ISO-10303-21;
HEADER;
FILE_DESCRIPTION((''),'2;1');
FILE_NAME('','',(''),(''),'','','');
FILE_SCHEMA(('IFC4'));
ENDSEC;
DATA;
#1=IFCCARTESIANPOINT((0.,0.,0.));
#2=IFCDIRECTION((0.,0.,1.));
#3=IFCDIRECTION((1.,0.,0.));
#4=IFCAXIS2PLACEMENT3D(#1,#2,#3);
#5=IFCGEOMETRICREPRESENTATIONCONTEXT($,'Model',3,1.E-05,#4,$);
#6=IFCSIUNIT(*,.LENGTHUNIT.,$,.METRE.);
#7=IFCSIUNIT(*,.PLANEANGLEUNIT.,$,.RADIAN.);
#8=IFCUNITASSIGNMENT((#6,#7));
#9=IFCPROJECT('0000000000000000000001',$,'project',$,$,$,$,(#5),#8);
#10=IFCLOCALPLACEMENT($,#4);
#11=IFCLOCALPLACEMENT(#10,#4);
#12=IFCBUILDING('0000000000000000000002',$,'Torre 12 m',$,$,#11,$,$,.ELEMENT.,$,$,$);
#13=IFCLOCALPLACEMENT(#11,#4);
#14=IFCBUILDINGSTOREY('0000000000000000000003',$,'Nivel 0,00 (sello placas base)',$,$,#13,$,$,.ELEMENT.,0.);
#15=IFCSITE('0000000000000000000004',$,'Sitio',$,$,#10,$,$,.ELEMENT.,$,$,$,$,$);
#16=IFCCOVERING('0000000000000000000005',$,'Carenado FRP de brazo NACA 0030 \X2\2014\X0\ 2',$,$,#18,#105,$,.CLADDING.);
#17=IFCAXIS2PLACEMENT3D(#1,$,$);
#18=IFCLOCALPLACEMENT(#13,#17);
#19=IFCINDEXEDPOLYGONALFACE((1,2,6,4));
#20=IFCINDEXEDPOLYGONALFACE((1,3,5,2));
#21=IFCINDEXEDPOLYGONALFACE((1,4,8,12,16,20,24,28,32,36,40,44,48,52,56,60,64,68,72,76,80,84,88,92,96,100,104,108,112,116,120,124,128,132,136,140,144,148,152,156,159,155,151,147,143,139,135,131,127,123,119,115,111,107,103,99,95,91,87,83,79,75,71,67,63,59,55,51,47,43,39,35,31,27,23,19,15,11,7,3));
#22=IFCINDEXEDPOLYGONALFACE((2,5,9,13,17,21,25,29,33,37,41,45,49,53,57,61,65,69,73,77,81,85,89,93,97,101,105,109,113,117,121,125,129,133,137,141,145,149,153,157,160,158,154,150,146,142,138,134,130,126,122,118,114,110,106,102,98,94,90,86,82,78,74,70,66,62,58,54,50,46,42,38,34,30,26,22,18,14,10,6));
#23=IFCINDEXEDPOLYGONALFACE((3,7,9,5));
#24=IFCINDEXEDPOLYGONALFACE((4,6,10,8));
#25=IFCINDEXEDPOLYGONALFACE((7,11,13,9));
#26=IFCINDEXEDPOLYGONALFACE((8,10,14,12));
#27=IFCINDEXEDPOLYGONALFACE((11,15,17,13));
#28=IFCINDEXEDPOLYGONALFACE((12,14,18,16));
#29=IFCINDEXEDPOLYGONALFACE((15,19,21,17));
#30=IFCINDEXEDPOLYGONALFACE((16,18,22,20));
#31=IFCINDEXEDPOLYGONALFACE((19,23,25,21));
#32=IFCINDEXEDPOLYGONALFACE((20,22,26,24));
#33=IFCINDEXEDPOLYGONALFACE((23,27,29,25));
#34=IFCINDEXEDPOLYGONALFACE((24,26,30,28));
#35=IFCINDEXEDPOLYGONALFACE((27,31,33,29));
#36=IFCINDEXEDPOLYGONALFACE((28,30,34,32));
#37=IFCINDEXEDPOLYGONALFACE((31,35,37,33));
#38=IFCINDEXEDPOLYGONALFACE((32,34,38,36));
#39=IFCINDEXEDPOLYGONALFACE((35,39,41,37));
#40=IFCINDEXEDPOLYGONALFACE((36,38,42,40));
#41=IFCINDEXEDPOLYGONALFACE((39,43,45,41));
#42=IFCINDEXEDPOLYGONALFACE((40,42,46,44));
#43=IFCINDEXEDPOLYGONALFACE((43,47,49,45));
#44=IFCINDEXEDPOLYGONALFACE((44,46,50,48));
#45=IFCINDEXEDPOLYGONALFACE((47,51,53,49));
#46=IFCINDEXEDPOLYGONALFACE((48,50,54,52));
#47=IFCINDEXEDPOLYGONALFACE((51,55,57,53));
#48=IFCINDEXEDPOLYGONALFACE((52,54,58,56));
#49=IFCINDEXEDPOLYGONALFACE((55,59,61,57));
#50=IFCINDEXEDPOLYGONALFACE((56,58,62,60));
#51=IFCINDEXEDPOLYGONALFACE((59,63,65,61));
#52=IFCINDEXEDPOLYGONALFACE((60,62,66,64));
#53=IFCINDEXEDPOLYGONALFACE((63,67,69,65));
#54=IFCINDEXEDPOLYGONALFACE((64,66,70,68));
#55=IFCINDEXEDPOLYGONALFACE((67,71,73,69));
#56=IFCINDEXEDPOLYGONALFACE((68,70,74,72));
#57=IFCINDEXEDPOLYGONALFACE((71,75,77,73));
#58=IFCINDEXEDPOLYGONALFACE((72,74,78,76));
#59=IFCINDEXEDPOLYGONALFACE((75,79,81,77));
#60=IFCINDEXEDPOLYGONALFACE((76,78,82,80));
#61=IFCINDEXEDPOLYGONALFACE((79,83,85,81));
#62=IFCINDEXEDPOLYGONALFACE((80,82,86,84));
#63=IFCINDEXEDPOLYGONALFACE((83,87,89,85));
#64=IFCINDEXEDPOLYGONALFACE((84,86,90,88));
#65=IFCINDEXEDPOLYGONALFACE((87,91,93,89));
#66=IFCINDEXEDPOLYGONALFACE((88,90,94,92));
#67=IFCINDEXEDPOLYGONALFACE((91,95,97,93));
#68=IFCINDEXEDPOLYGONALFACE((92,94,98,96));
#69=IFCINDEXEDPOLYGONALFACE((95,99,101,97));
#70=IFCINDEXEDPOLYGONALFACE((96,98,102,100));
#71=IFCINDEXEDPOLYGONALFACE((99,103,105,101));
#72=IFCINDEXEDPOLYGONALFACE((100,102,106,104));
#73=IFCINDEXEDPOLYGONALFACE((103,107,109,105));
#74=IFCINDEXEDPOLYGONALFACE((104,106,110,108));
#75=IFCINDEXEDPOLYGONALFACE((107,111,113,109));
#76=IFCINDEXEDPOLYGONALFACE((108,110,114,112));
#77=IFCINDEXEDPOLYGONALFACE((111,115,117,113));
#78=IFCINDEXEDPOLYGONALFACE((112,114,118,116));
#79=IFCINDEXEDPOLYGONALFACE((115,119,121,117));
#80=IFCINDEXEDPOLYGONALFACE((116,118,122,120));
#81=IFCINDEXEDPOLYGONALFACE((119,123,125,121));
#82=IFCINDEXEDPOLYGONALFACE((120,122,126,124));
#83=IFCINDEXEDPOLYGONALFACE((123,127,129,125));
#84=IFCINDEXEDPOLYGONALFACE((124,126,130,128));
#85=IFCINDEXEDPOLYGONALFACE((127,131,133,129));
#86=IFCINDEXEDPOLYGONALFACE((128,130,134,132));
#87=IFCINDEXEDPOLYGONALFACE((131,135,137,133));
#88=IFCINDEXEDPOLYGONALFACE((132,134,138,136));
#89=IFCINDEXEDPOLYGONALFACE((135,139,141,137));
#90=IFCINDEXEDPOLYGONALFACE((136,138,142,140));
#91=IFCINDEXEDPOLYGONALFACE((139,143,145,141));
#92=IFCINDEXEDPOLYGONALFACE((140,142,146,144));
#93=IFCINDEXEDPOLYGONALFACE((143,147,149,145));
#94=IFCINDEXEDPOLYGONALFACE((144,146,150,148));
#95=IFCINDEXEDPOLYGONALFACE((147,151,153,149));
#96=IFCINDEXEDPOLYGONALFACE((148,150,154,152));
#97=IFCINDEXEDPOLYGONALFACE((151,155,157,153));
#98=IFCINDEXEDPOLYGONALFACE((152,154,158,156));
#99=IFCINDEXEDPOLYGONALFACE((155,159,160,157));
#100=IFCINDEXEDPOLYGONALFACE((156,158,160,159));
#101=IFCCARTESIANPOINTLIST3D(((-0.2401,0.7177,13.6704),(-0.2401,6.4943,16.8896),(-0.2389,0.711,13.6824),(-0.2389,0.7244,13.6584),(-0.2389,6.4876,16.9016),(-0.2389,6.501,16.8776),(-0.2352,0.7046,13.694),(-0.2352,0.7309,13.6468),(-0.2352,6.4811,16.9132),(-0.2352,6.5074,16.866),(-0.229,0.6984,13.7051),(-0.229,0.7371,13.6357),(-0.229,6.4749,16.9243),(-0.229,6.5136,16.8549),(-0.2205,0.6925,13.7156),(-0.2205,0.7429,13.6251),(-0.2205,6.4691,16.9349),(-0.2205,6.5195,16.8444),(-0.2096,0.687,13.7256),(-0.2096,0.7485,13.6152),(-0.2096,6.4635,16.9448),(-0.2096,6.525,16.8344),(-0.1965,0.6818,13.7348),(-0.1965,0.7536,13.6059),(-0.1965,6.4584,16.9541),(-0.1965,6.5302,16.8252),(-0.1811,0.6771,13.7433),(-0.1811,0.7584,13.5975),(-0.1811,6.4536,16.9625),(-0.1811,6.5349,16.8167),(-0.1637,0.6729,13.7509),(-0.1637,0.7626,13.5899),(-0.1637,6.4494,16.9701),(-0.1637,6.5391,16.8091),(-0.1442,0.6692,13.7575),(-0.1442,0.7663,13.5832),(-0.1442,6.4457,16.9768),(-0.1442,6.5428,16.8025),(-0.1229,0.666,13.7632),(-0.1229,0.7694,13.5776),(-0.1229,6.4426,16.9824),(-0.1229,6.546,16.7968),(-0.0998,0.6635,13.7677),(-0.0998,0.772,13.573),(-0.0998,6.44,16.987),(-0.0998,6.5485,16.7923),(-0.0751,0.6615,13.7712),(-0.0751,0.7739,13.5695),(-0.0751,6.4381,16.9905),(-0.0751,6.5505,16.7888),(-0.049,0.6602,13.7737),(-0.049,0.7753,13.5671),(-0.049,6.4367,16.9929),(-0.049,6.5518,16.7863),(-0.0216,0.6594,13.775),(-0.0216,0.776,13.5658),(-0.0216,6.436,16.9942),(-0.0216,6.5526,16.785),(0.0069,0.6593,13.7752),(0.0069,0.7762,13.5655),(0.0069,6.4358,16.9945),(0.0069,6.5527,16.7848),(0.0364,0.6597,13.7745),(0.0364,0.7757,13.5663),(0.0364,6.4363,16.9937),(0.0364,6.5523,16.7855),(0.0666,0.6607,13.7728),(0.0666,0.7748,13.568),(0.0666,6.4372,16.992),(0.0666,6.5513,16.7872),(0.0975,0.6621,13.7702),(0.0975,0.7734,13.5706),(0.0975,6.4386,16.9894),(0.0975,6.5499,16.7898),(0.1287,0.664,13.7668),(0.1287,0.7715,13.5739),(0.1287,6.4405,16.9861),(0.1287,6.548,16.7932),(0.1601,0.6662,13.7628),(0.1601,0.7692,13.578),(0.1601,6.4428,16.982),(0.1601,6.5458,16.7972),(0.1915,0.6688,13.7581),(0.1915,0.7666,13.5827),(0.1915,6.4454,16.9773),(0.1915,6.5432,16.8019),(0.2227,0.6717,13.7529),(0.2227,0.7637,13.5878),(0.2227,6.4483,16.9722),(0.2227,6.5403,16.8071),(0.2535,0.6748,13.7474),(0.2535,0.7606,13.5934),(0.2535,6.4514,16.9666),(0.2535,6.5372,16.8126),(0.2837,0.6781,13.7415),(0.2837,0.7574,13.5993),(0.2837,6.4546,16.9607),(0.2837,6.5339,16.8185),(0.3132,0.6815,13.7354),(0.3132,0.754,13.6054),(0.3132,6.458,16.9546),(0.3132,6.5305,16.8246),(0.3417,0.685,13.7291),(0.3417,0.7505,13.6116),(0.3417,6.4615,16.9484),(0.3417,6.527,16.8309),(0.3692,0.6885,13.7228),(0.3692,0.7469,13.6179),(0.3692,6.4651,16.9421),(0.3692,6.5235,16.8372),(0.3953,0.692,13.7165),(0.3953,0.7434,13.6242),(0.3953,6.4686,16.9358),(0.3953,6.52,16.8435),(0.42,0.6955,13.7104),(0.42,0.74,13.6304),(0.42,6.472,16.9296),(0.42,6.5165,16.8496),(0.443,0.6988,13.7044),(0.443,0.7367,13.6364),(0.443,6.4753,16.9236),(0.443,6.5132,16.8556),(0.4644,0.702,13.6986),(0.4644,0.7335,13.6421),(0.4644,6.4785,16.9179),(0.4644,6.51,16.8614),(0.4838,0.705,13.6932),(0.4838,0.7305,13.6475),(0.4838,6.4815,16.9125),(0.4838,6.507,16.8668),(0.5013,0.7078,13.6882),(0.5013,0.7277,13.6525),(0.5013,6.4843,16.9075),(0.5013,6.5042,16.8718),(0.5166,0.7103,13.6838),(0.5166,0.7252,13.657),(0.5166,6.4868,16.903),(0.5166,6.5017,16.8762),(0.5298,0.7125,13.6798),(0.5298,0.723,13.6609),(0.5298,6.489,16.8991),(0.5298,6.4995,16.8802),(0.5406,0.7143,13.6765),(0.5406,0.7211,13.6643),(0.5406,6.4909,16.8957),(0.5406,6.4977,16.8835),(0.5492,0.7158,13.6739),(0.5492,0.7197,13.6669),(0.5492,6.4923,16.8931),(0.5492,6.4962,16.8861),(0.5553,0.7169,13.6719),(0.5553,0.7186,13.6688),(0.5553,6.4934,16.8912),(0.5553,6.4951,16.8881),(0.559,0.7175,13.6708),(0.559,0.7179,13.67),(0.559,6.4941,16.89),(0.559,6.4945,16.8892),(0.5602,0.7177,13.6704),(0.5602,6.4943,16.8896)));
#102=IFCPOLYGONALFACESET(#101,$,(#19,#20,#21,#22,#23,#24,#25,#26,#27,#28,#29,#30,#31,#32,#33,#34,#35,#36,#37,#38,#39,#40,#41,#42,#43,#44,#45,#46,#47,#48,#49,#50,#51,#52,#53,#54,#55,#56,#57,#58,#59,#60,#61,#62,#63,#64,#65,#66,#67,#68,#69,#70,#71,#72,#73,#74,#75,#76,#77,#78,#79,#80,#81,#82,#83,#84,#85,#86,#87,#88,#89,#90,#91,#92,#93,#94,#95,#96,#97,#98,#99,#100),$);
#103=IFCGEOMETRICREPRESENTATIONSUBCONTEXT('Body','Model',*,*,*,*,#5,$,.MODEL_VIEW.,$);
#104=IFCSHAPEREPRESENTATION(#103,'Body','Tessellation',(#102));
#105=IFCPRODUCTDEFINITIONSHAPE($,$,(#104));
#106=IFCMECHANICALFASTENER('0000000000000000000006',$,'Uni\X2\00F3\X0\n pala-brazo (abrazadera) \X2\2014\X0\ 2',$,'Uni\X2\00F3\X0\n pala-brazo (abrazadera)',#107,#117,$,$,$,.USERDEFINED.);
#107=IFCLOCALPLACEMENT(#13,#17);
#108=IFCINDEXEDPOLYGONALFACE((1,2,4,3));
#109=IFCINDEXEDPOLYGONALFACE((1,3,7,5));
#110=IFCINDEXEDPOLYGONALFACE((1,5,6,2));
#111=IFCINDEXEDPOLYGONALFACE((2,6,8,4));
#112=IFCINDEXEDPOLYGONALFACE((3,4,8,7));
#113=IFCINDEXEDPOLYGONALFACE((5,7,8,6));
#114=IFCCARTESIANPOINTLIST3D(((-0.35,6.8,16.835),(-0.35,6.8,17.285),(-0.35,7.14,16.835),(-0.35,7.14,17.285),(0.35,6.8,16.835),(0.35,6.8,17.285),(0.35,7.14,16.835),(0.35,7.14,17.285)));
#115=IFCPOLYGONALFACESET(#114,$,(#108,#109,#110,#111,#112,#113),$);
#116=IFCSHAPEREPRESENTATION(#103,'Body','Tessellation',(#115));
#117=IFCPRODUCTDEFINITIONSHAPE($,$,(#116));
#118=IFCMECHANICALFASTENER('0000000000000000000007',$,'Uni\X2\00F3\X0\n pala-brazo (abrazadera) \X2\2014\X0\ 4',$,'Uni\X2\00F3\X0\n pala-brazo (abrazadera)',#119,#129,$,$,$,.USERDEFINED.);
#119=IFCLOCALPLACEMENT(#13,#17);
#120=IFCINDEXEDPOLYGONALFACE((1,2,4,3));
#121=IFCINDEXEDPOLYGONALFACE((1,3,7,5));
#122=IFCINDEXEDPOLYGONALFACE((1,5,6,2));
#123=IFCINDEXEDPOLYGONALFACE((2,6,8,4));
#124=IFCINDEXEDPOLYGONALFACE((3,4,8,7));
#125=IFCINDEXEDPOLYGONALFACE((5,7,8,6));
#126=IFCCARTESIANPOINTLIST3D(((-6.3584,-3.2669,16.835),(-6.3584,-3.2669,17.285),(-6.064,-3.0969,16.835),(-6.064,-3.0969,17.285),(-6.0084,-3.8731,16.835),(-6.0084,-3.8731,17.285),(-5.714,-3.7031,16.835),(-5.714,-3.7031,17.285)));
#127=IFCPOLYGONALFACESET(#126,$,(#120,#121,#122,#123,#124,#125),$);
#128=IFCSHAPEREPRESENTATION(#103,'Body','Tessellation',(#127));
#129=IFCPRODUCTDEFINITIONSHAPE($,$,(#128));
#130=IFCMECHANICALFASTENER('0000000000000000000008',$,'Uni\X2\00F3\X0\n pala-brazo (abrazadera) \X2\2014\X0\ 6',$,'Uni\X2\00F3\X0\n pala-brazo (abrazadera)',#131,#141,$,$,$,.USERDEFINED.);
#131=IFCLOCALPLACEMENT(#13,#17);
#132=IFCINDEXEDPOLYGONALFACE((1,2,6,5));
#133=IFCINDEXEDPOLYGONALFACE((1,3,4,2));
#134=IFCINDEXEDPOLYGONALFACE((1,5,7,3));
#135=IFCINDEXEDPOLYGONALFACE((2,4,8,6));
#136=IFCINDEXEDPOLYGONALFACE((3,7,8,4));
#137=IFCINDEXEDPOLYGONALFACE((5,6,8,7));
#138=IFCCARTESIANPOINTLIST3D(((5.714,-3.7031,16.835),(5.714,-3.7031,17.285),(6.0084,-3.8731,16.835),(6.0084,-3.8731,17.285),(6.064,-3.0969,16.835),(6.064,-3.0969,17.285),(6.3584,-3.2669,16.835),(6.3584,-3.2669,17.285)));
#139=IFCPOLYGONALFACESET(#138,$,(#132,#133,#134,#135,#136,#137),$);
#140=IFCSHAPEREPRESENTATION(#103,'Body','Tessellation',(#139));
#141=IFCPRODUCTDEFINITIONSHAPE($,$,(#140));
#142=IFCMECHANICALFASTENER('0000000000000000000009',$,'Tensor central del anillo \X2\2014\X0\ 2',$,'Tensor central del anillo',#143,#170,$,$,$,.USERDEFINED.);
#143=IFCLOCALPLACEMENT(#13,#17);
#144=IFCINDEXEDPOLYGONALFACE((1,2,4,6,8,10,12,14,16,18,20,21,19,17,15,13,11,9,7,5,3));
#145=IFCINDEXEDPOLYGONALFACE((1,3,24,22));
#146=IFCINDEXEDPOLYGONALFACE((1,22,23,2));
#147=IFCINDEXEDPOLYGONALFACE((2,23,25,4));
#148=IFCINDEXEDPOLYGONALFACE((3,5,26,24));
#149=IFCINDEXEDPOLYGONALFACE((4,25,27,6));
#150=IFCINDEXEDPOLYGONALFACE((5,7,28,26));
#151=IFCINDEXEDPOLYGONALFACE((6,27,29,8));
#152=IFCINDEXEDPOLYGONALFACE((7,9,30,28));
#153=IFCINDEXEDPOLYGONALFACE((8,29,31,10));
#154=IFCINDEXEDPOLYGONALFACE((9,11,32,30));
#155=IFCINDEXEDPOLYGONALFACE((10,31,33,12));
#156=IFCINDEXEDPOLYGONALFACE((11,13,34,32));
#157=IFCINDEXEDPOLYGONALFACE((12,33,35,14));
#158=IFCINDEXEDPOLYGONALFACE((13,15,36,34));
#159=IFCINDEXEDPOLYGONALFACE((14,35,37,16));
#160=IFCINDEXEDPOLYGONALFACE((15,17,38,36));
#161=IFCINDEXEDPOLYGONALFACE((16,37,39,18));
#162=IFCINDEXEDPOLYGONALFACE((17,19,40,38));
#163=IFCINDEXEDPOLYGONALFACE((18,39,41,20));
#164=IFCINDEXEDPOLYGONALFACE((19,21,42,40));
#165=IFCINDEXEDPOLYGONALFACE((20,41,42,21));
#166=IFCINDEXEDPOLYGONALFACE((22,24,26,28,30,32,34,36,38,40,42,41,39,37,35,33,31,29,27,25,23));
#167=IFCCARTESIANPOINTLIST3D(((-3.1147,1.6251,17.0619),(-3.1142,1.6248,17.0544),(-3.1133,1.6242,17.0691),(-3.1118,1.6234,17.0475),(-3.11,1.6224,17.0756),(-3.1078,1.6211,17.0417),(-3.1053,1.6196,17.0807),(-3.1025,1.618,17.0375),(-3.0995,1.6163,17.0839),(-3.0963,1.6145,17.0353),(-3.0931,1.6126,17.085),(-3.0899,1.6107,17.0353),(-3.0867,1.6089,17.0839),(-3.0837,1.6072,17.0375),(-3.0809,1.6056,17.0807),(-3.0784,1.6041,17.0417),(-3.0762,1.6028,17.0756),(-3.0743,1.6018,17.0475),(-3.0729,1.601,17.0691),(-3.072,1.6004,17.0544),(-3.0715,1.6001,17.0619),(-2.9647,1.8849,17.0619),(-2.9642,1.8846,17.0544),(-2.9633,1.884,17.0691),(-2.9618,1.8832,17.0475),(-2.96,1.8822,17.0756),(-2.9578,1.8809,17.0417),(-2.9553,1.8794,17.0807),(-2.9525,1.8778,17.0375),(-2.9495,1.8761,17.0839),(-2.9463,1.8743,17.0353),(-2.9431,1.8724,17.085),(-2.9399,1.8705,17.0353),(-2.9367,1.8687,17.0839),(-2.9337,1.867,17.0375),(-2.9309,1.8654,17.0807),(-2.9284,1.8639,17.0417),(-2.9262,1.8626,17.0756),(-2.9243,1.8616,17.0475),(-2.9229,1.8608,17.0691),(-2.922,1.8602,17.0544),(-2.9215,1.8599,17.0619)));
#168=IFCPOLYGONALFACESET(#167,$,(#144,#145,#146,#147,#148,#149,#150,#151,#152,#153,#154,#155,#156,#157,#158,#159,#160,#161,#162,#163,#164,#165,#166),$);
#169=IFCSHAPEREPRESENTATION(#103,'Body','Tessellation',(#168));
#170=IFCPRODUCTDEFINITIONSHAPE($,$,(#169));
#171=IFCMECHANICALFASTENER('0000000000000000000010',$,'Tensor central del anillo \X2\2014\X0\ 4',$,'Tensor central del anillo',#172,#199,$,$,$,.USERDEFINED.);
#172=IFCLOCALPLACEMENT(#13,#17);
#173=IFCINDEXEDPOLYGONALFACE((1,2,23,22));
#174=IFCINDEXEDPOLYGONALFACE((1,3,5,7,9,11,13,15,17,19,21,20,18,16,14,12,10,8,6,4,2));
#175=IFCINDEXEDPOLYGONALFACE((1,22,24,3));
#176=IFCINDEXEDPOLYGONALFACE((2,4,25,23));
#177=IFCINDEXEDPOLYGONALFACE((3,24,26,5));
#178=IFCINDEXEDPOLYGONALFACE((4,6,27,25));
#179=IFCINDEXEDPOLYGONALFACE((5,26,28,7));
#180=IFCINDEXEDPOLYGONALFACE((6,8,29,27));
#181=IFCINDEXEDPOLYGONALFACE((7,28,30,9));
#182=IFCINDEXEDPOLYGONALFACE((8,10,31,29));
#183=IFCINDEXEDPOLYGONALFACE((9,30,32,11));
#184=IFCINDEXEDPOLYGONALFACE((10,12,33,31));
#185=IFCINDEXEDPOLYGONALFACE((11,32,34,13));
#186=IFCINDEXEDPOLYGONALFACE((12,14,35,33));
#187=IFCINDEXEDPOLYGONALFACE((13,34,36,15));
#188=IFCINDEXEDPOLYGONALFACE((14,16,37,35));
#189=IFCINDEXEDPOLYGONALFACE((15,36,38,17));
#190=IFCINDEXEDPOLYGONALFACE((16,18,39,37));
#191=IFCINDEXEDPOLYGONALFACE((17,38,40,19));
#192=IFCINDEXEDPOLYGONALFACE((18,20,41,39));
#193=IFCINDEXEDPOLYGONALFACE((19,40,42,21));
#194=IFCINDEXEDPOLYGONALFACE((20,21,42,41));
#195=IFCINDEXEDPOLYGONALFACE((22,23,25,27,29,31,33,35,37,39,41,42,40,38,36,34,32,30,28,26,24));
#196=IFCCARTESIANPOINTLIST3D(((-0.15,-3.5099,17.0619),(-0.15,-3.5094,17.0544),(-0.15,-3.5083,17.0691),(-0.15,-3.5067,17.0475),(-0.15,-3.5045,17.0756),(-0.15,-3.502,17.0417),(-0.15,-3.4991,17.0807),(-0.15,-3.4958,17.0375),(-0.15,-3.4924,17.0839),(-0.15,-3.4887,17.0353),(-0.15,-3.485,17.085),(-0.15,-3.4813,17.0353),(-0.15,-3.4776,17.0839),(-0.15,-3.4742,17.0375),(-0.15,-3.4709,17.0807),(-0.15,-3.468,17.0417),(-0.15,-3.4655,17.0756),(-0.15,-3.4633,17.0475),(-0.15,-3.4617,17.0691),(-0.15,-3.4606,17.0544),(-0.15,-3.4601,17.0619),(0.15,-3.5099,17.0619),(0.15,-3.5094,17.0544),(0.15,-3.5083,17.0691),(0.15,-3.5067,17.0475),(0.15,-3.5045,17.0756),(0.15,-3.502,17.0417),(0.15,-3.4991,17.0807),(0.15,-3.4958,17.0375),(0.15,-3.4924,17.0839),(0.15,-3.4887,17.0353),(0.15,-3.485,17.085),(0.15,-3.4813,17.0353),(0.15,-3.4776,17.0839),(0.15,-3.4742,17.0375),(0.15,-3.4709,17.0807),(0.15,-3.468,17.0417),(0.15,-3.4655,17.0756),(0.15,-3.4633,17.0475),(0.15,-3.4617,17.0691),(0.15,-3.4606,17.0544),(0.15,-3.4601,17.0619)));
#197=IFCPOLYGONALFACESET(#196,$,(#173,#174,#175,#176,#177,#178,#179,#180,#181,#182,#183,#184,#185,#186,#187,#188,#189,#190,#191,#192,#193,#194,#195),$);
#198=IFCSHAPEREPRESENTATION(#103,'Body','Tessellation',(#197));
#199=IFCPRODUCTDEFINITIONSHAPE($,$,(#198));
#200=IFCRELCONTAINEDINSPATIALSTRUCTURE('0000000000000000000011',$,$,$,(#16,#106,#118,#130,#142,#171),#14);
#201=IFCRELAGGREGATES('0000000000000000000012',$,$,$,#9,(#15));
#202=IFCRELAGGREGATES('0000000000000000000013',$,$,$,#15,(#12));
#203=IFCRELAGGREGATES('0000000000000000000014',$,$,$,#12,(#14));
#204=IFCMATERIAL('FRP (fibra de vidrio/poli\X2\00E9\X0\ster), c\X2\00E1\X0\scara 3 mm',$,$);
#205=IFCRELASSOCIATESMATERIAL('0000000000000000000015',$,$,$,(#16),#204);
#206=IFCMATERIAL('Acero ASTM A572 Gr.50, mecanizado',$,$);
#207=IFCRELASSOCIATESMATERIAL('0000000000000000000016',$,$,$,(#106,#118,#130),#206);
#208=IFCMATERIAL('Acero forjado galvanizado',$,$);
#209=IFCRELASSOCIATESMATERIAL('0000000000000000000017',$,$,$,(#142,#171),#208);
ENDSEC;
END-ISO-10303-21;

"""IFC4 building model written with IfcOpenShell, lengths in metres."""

from ifc_helpers import new_model, si_unit, frame, origin, origin_with_axes, origin_2d, place, context, subcontext, project, spatial, polyline, rectangle, circle, outline, extrude, material, element, save


model = new_model("IFC4")

# Units and contexts
model_context = context("Model", 3, precision=1e-05, world=origin_with_axes())
body_context = subcontext(model_context, "Body", "Model", "MODEL_VIEW")
ifc_project = project(units=[si_unit("LENGTHUNIT", "METRE"), si_unit("PLANEANGLEUNIT", "RADIAN")], contexts=[model_context])

# Site, building, storey
site_placement = place(None, origin_with_axes())
site = spatial("IfcSite", under=ifc_project, at=site_placement, Name="Sitio", CompositionType="ELEMENT")
building_placement = place(site_placement, origin_with_axes())
building = spatial("IfcBuilding", under=site, at=building_placement, Name="Torre 12 m", CompositionType="ELEMENT")
storey_placement = place(building_placement, origin_with_axes())
storey = spatial("IfcBuildingStorey", under=building, at=storey_placement, Name="Nivel 0,00 (sello placas base)", CompositionType="ELEMENT", Elevation=0.0)

# Shared definitions
ifc_material_1 = material(Name="Acero ASTM A572 Gr.50, mecanizado")

# Covering
ifc_material_2 = material(Name="FRP (fibra de vidrio/poliéster), cáscara 3 mm")
covering_1_placement = place(storey_placement, frame((0.0, 0.7177, 13.6704), z_axis=(0.0, 0.873511, 0.486804), x_axis=(-1.0, 0.0, 0.0)))
element("IfcCovering", 1, at=covering_1_placement, inside=storey, material=ifc_material_2, Name="Carenado FRP de brazo NACA 0030 — 2", PredefinedType="CLADDING", context=body_context, shape_type="SweptSolid", body=[
    extrude(outline(polyline([(0.2401, 0.0), (0.2389, 0.0138), (0.2352, 0.027), (0.229, 0.0397), (0.2205, 0.0518), (0.2096, 0.0632), (0.1965, 0.0738), (0.1811, 0.0834), (0.1637, 0.0921), (0.1442, 0.0997), (0.1229, 0.1062), (0.0998, 0.1115), (0.0751, 0.1155), (0.049, 0.1182), (0.0216, 0.1197), (-0.0069, 0.12), (-0.0364, 0.1192), (-0.0666, 0.1172), (-0.0975, 0.1143), (-0.1287, 0.1104), (-0.1601, 0.1058), (-0.1915, 0.1004), (-0.2227, 0.0945), (-0.2535, 0.0881), (-0.2837, 0.0814), (-0.3132, 0.0744), (-0.3417, 0.0672), (-0.3692, 0.06), (-0.3953, 0.0528), (-0.42, 0.0458), (-0.443, 0.0389), (-0.4644, 0.0323), (-0.4838, 0.0262), (-0.5013, 0.0205), (-0.5166, 0.0153), (-0.5298, 0.0108), (-0.5406, 0.007), (-0.5492, 0.004), (-0.5553, 0.0018), (-0.559, 0.0004), (-0.5602, 0.0), (-0.559, -0.0004), (-0.5553, -0.0018), (-0.5492, -0.004), (-0.5406, -0.007), (-0.5298, -0.0108), (-0.5166, -0.0153), (-0.5013, -0.0205), (-0.4838, -0.0262), (-0.4644, -0.0323), (-0.443, -0.0389), (-0.42, -0.0458), (-0.3953, -0.0528), (-0.3692, -0.06), (-0.3417, -0.0672), (-0.3132, -0.0744), (-0.2837, -0.0814), (-0.2535, -0.0881), (-0.2227, -0.0945), (-0.1915, -0.1004), (-0.1601, -0.1058), (-0.1287, -0.1104), (-0.0975, -0.1143), (-0.0666, -0.1172), (-0.0364, -0.1192), (-0.0069, -0.12), (0.0216, -0.1197), (0.049, -0.1182), (0.0751, -0.1155), (0.0998, -0.1115), (0.1229, -0.1062), (0.1442, -0.0997), (0.1637, -0.0921), (0.1811, -0.0834), (0.1965, -0.0738), (0.2096, -0.0632), (0.2205, -0.0518), (0.229, -0.0397), (0.2352, -0.027), (0.2389, -0.0138), (0.2401, 0.0)])), origin(), (0.0, 0.0, 1.0), 6.613),
])

# Mechanical fasteners
for number, where, z_axis, x_axis, name in (
    (2, (0.0, 6.97, 16.835), (0.0, 0.0, 1.0), (-1.0, 0.0, 0.0), "Unión pala-brazo (abrazadera) — 2"),
    (3, (-6.0362, -3.485, 16.835), (0.0, 0.0, 1.0), (0.5, -0.866025, 0.0), "Unión pala-brazo (abrazadera) — 4"),
    (4, (6.0362, -3.485, 16.835), (0.0, 0.0, 1.0), (0.5, 0.866025, 0.0), "Unión pala-brazo (abrazadera) — 6"),
):
    element("IfcMechanicalFastener", number, at=place(storey_placement, frame(where, z_axis=z_axis, x_axis=x_axis)), inside=storey, material=ifc_material_1, Name=name, ObjectType="Unión pala-brazo (abrazadera)", PredefinedType="USERDEFINED", context=body_context, shape_type="SweptSolid", body=[
        extrude(rectangle(XDim=0.7, YDim=0.34, at=origin_2d()), origin(), (0.0, 0.0, 1.0), 0.45),
    ])
ifc_material_3 = material(Name="Acero forjado galvanizado")
for number, where, z_axis, x_axis, name in (
    (5, (-2.9431, 1.8724, 17.06), (-0.5, -0.866025, 0.0), (0.0, 0.0, 1.0), "Tensor central del anillo — 2"),
    (6, (-0.15, -3.485, 17.06), (1.0, 0.0, 0.0), (0.0, 0.0, 1.0), "Tensor central del anillo — 4"),
):
    element("IfcMechanicalFastener", number, at=place(storey_placement, frame(where, z_axis=z_axis, x_axis=x_axis)), inside=storey, material=ifc_material_3, Name=name, ObjectType="Tensor central del anillo", PredefinedType="USERDEFINED", context=body_context, shape_type="SweptSolid", body=[
        extrude(circle(Radius=0.025, at=origin_2d()), origin(), (0.0, 0.0, 1.0), 0.3),
    ])

save(model, "model.ifc")
